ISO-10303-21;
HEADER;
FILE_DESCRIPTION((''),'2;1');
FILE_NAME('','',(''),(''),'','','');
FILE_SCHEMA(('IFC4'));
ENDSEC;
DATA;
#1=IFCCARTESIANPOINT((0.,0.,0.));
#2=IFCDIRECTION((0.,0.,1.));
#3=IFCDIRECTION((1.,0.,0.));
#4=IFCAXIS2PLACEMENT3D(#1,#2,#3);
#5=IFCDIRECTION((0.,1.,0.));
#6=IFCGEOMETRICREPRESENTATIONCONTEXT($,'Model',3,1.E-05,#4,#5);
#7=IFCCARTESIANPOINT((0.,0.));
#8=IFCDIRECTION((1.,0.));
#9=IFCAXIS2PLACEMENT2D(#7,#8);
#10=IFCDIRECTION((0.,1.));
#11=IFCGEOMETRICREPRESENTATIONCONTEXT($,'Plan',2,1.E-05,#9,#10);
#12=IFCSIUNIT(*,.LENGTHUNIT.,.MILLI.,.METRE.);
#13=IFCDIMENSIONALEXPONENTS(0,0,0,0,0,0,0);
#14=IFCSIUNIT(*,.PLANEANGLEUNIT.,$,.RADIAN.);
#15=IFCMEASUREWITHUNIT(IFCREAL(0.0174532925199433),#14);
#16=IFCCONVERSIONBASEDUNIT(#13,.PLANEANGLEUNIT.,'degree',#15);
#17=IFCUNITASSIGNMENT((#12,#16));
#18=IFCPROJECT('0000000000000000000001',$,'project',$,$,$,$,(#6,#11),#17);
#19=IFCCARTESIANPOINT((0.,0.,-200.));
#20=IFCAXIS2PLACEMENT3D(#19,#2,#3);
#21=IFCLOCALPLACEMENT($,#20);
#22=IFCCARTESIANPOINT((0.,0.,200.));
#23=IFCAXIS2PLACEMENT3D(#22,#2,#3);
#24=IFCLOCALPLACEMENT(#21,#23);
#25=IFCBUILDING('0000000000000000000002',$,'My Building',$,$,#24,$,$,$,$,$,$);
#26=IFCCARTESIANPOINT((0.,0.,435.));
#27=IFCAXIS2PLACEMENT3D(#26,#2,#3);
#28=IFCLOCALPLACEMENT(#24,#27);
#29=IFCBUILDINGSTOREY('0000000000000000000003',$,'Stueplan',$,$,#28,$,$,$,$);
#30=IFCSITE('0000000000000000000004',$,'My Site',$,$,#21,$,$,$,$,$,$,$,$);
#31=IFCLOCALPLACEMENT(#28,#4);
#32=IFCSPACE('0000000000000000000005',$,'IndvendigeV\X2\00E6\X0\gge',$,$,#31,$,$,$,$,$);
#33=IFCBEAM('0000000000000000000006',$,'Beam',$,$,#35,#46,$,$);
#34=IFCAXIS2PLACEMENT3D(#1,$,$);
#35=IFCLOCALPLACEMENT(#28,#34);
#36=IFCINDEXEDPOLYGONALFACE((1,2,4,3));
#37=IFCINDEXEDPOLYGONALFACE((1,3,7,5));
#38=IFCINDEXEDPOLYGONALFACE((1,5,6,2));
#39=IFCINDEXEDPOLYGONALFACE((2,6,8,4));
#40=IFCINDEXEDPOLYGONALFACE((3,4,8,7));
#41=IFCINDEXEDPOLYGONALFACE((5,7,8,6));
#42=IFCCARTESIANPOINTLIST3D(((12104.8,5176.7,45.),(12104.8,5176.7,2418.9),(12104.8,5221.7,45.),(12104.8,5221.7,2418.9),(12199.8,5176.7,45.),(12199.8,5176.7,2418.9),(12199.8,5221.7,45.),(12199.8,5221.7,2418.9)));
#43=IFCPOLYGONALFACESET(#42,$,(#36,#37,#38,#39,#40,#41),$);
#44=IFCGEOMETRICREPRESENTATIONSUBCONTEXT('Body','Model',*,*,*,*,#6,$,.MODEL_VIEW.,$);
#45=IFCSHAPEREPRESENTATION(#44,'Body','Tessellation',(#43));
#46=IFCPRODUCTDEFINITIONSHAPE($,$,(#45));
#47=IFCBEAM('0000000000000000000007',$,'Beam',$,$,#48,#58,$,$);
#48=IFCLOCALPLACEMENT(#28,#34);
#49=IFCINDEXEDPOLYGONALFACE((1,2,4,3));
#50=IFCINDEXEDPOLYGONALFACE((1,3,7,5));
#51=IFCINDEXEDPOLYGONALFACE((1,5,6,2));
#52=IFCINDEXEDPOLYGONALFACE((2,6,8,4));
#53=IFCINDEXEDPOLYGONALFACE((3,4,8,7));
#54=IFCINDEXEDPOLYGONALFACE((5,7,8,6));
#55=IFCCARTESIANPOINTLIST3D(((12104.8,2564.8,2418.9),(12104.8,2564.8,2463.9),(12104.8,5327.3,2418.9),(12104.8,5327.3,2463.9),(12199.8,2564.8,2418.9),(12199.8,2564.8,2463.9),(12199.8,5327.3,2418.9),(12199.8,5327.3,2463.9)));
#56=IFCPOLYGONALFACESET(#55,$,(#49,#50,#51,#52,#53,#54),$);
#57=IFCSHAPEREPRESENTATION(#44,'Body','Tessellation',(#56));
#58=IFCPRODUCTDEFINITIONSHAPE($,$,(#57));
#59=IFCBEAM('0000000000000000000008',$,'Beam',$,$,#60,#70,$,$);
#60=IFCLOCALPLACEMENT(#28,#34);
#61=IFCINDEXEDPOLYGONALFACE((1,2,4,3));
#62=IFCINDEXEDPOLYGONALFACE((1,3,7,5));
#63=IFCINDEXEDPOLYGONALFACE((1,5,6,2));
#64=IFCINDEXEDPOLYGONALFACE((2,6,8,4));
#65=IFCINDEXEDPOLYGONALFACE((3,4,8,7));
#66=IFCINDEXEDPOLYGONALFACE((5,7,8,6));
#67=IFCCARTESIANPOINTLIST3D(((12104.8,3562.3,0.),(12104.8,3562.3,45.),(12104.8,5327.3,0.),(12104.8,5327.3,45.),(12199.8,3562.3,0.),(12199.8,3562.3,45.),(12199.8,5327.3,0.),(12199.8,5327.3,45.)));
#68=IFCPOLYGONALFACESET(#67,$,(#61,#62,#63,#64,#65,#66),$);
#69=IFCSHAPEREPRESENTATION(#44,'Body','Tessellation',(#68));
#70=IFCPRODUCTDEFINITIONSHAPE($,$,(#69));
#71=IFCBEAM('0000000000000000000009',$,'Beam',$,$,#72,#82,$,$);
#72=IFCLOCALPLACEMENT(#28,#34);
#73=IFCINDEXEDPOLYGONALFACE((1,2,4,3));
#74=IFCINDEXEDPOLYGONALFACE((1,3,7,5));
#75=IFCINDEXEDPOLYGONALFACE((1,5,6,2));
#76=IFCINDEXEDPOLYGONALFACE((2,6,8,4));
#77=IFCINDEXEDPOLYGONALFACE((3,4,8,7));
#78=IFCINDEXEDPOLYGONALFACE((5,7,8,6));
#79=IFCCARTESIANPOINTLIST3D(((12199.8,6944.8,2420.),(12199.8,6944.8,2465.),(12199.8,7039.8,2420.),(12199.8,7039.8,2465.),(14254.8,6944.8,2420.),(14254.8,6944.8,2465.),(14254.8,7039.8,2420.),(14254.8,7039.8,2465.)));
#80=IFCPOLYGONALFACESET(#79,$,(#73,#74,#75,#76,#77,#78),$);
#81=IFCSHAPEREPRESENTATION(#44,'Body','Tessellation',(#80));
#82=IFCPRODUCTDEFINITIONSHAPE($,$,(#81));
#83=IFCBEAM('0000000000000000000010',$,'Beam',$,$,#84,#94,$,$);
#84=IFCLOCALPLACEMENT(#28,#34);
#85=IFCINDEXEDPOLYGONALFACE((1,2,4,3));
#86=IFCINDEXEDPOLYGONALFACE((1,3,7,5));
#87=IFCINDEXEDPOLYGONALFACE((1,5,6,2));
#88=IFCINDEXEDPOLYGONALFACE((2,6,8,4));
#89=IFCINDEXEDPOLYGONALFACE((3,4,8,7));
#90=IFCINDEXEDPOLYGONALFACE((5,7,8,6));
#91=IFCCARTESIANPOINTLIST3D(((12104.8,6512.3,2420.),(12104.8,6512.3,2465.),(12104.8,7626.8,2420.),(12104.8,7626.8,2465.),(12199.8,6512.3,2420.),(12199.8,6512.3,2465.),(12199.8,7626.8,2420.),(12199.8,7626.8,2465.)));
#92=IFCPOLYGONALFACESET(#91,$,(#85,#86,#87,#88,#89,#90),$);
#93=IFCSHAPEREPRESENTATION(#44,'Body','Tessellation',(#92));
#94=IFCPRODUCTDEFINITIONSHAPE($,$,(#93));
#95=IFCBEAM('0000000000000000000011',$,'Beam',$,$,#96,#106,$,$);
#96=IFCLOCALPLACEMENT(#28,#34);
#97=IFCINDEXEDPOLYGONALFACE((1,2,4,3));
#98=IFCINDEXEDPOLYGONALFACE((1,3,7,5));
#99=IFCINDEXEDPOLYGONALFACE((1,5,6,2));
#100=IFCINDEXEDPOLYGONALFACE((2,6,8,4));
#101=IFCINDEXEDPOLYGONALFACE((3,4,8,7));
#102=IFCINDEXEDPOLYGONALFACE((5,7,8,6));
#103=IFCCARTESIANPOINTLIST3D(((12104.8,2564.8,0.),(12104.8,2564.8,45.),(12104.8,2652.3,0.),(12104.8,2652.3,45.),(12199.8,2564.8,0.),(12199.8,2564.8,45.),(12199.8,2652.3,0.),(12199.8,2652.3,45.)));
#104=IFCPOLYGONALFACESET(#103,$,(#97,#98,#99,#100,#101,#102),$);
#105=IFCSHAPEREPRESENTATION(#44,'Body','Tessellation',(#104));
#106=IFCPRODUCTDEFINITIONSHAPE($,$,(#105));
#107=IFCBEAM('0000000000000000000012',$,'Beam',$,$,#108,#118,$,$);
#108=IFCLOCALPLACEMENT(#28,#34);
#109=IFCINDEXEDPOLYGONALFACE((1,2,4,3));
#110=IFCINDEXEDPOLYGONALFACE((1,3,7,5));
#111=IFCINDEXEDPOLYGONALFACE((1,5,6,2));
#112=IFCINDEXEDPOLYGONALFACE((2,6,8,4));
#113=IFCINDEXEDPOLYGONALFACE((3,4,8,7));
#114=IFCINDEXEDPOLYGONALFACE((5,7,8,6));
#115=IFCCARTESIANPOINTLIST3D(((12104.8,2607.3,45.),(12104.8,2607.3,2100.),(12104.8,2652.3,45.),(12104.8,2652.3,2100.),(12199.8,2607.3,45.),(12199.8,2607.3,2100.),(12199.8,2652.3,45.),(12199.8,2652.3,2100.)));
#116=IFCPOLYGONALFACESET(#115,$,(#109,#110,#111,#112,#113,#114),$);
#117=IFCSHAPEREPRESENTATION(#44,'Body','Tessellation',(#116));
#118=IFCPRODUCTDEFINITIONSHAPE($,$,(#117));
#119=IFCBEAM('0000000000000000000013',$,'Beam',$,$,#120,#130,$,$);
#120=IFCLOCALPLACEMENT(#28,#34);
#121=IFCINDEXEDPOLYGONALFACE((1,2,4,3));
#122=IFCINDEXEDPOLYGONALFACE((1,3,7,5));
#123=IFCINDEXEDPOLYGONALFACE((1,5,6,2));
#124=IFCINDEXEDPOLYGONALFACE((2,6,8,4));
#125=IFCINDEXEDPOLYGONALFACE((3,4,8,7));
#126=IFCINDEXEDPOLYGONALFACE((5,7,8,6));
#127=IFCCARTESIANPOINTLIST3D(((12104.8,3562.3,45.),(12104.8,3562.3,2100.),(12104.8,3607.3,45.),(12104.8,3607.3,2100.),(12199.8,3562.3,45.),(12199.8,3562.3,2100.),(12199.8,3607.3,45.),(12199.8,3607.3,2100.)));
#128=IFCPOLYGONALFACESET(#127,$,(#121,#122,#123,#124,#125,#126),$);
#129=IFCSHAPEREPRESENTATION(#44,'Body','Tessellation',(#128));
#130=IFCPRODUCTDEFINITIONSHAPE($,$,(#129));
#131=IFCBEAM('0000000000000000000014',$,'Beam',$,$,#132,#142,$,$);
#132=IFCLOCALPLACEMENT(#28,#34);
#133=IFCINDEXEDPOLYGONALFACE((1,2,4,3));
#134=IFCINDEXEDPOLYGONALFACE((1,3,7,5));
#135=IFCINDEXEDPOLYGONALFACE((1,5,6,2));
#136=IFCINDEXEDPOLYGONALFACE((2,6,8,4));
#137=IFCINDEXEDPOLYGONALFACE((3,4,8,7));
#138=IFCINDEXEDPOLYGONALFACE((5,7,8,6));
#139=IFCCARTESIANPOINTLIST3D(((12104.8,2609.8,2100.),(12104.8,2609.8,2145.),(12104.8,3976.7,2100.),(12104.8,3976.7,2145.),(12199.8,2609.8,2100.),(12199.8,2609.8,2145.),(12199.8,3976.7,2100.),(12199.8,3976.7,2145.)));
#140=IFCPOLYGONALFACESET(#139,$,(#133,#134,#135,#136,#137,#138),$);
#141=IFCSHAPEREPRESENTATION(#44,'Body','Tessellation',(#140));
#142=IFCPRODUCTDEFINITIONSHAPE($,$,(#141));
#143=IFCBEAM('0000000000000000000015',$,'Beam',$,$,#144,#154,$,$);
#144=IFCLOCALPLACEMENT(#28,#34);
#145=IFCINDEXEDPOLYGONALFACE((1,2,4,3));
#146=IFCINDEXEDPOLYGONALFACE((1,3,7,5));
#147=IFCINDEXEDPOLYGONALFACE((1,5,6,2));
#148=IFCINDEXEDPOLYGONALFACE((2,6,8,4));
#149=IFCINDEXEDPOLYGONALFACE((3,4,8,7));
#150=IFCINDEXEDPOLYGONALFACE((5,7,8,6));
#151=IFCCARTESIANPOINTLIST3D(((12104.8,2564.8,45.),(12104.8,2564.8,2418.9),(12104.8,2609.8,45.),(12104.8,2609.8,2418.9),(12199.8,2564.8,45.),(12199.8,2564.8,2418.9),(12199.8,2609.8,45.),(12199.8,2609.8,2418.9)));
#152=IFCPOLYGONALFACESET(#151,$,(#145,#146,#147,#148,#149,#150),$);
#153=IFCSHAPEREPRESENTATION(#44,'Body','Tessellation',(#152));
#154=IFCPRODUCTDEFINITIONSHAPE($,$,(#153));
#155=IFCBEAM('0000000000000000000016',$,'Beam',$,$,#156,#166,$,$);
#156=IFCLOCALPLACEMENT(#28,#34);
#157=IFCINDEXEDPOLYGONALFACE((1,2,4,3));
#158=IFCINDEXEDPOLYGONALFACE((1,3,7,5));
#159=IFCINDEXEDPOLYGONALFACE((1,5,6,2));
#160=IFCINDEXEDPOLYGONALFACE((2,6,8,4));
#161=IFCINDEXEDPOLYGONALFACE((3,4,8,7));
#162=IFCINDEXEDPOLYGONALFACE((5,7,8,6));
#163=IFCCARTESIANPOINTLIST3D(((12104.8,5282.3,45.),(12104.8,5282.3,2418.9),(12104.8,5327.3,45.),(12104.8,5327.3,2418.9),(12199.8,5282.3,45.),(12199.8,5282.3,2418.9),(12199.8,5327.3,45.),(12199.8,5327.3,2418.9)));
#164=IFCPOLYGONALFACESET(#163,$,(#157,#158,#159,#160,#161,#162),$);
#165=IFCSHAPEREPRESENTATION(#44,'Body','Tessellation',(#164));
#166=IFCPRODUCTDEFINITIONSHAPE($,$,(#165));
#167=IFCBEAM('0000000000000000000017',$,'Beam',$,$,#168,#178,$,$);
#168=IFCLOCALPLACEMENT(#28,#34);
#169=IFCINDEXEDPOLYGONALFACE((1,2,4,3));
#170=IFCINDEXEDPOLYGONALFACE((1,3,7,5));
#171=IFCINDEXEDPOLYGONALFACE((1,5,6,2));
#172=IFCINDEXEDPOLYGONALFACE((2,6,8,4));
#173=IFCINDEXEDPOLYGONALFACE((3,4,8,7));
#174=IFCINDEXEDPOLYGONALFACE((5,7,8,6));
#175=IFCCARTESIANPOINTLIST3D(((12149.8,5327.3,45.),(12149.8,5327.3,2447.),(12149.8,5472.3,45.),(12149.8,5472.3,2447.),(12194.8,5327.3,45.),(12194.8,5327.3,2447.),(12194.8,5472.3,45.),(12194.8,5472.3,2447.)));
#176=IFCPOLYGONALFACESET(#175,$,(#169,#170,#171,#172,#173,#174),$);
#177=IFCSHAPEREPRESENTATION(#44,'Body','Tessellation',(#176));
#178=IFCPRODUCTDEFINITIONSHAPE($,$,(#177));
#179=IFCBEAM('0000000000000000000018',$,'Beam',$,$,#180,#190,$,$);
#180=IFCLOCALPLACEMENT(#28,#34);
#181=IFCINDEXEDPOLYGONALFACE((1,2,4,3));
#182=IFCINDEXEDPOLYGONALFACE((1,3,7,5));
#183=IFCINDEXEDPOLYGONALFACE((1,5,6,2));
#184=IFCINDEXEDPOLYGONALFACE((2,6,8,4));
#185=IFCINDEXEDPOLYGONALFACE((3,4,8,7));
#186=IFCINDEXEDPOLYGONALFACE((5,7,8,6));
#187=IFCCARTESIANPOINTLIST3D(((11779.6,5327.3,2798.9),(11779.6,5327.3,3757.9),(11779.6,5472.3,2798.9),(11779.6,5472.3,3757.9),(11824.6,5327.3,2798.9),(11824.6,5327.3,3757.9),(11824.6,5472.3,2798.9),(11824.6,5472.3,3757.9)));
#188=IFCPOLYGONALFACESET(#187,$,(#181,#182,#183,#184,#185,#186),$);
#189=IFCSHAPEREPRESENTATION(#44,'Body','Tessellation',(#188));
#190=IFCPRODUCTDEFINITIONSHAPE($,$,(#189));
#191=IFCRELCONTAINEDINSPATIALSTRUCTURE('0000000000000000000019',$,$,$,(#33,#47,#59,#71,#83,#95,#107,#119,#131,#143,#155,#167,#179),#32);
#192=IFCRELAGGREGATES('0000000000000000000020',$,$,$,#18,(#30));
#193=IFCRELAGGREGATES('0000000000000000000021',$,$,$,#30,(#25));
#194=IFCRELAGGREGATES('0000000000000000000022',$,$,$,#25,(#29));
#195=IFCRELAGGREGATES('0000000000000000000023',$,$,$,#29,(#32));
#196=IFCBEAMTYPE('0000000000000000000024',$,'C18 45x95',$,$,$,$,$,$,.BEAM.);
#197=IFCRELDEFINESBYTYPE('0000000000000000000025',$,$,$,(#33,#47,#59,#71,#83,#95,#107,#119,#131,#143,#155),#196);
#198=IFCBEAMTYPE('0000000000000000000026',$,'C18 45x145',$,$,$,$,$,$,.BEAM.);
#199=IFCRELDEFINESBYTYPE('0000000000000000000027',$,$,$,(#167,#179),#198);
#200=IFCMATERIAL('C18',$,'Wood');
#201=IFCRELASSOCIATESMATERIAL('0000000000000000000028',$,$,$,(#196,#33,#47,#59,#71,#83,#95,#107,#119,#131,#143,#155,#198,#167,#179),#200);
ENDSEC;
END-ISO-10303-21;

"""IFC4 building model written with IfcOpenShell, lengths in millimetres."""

from ifc_helpers import new_model, entity, si_unit, converted_unit, direction, frame, origin_with_axes, origin_2d_with_axis, place, context, subcontext, project, spatial, rectangle, extrude, material, material_profile, profile_set, profile_usage, type_object, element, save


model = new_model("IFC4")

# Units and contexts
model_context = context("Model", 3, precision=1e-05, world=origin_with_axes(), true_north=direction((0.0, 1.0, 0.0)))
plan_context = context("Plan", 2, precision=1e-05, world=origin_2d_with_axis(), true_north=direction((0.0, 1.0)))
body_context_1 = subcontext(model_context, "Body", "Model", "MODEL_VIEW")
ifc_project = project(units=[si_unit("LENGTHUNIT", "METRE", prefix="MILLI"), converted_unit("PLANEANGLEUNIT", "degree", entity("IfcReal", 0.0174532925199433), si_unit("PLANEANGLEUNIT", "RADIAN"), dimensions=[0, 0, 0, 0, 0, 0, 0])], contexts=[model_context, plan_context])

# Site, building, storey, space
site_placement = place(None, frame((0.0, 0.0, -200.0), z_axis=(0.0, 0.0, 1.0), x_axis=(1.0, 0.0, 0.0)))
site = spatial("IfcSite", under=ifc_project, at=site_placement, Name="My Site")
building_placement = place(site_placement, frame((0.0, 0.0, 200.0), z_axis=(0.0, 0.0, 1.0), x_axis=(1.0, 0.0, 0.0)))
building = spatial("IfcBuilding", under=site, at=building_placement, Name="My Building")
storey_placement = place(building_placement, frame((0.0, 0.0, 435.0), z_axis=(0.0, 0.0, 1.0), x_axis=(1.0, 0.0, 0.0)))
storey = spatial("IfcBuildingStorey", under=building, at=storey_placement, Name="Stueplan")
space_1_placement = place(storey_placement, frame((0.0, 0.0, 0.0), z_axis=(0.0, 0.0, 1.0), x_axis=(1.0, 0.0, 0.0)))
space_1 = spatial("IfcSpace", under=storey, at=space_1_placement, Name="IndvendigeVægge")

# Beams
ifc_material = material(Name="C18", Category="Wood")
ifc_material_profile_1 = material_profile(ifc_material, rectangle(XDim=45.0, YDim=95.0))
ifc_profile_set_1 = profile_set([ifc_material_profile_1], Name="woodStructural")
beam_type_1 = type_object("IfcBeamType", Name="C18 45x95", PredefinedType="BEAM", material=ifc_profile_set_1)
ifc_profile_usage_1 = profile_usage(ifc_profile_set_1)
beam_1_placement = place(space_1_placement, frame((12152.3, 5199.2, 45.0), z_axis=(0.0, 0.0, 1.0), x_axis=(0.0, -1.0, 0.0)))
element("IfcBeam", 1, at=beam_1_placement, inside=space_1, type_object=beam_type_1, material=ifc_profile_usage_1, Name="Beam", context=body_context_1, shape_type="SweptSolid", body=[
    extrude(rectangle(XDim=45.0, YDim=95.0), origin_with_axes(), (0.0, 0.0, 1.0), 2373.9),
])
ifc_profile_usage_2 = profile_usage(ifc_profile_set_1, cardinal=5)
beam_2_placement = place(space_1_placement, frame((12152.3, 2564.8, 2441.4), z_axis=(0.0, 1.0, 0.0), x_axis=(0.0, 0.0, 1.0)))
element("IfcBeam", 2, at=beam_2_placement, inside=space_1, type_object=beam_type_1, material=ifc_profile_usage_2, Name="Beam", context=body_context_1, shape_type="SweptSolid", body=[
    extrude(rectangle(XDim=45.0, YDim=95.0), origin_with_axes(), (0.0, 0.0, 1.0), 2762.5),
])
ifc_profile_usage_3 = profile_usage(ifc_profile_set_1, cardinal=5)
beam_3_placement = place(space_1_placement, frame((12152.3, 3562.3, 22.5), z_axis=(0.0, 1.0, 0.0), x_axis=(0.0, 0.0, 1.0)))
element("IfcBeam", 3, at=beam_3_placement, inside=space_1, type_object=beam_type_1, material=ifc_profile_usage_3, Name="Beam", context=body_context_1, shape_type="SweptSolid", body=[
    extrude(rectangle(XDim=45.0, YDim=95.0), origin_with_axes(), (0.0, 0.0, 1.0), 1765.0),
])
ifc_profile_usage_4 = profile_usage(ifc_profile_set_1, cardinal=5)
beam_4_placement = place(space_1_placement, frame((12199.8, 6992.3, 2442.5), z_axis=(1.0, 0.0, 0.0), x_axis=(0.0, 0.0, 1.0)))
element("IfcBeam", 4, at=beam_4_placement, inside=space_1, type_object=beam_type_1, material=ifc_profile_usage_4, Name="Beam", context=body_context_1, shape_type="SweptSolid", body=[
    extrude(rectangle(XDim=45.0, YDim=95.0), origin_with_axes(), (0.0, 0.0, 1.0), 2055.0),
])
ifc_profile_usage_5 = profile_usage(ifc_profile_set_1, cardinal=5)
beam_5_placement = place(space_1_placement, frame((12152.3, 6512.3, 2442.5), z_axis=(0.0, 1.0, 0.0), x_axis=(0.0, 0.0, 1.0)))
element("IfcBeam", 5, at=beam_5_placement, inside=space_1, type_object=beam_type_1, material=ifc_profile_usage_5, Name="Beam", context=body_context_1, shape_type="SweptSolid", body=[
    extrude(rectangle(XDim=45.0, YDim=95.0), origin_with_axes(), (0.0, 0.0, 1.0), 1114.5),
])
ifc_profile_usage_6 = profile_usage(ifc_profile_set_1, cardinal=5)
beam_6_placement = place(space_1_placement, frame((12152.3, 2652.3, 22.5), z_axis=(0.0, -1.0, 0.0), x_axis=(0.0, 0.0, 1.0)))
element("IfcBeam", 6, at=beam_6_placement, inside=space_1, type_object=beam_type_1, material=ifc_profile_usage_6, Name="Beam", context=body_context_1, shape_type="SweptSolid", body=[
    extrude(rectangle(XDim=45.0, YDim=95.0), origin_with_axes(), (0.0, 0.0, 1.0), 87.5),
])
ifc_profile_usage_7 = profile_usage(ifc_profile_set_1)
beam_7_placement = place(space_1_placement, frame((12152.3, 2629.8, 45.0), z_axis=(0.0, 0.0, 1.0), x_axis=(0.0, -1.0, 0.0)))
element("IfcBeam", 7, at=beam_7_placement, inside=space_1, type_object=beam_type_1, material=ifc_profile_usage_7, Name="Beam", context=body_context_1, shape_type="SweptSolid", body=[
    extrude(rectangle(XDim=45.0, YDim=95.0), origin_with_axes(), (0.0, 0.0, 1.0), 2055.0),
])
ifc_profile_usage_8 = profile_usage(ifc_profile_set_1)
beam_8_placement = place(space_1_placement, frame((12152.3, 3584.8, 45.0), z_axis=(0.0, 0.0, 1.0), x_axis=(0.0, -1.0, 0.0)))
element("IfcBeam", 8, at=beam_8_placement, inside=space_1, type_object=beam_type_1, material=ifc_profile_usage_8, Name="Beam", context=body_context_1, shape_type="SweptSolid", body=[
    extrude(rectangle(XDim=45.0, YDim=95.0), origin_with_axes(), (0.0, 0.0, 1.0), 2055.0),
])
ifc_profile_usage_9 = profile_usage(ifc_profile_set_1, cardinal=5)
beam_9_placement = place(space_1_placement, frame((12152.3, 3976.7, 2122.5), z_axis=(0.0, -1.0, 0.0), x_axis=(0.0, 0.0, 1.0)))
element("IfcBeam", 9, at=beam_9_placement, inside=space_1, type_object=beam_type_1, material=ifc_profile_usage_9, Name="Beam", context=body_context_1, shape_type="SweptSolid", body=[
    extrude(rectangle(XDim=45.0, YDim=95.0), origin_with_axes(), (0.0, 0.0, 1.0), 1366.9),
])
ifc_profile_usage_10 = profile_usage(ifc_profile_set_1)
beam_10_placement = place(space_1_placement, frame((12152.3, 2587.3, 45.0), z_axis=(0.0, 0.0, 1.0), x_axis=(0.0, -1.0, 0.0)))
element("IfcBeam", 10, at=beam_10_placement, inside=space_1, type_object=beam_type_1, material=ifc_profile_usage_10, Name="Beam", context=body_context_1, shape_type="SweptSolid", body=[
    extrude(rectangle(XDim=45.0, YDim=95.0), origin_with_axes(), (0.0, 0.0, 1.0), 2373.9),
])
ifc_profile_usage_11 = profile_usage(ifc_profile_set_1)
beam_11_placement = place(space_1_placement, frame((12152.3, 5304.8, 45.0), z_axis=(0.0, 0.0, 1.0), x_axis=(0.0, -1.0, 0.0)))
element("IfcBeam", 11, at=beam_11_placement, inside=space_1, type_object=beam_type_1, material=ifc_profile_usage_11, Name="Beam", context=body_context_1, shape_type="SweptSolid", body=[
    extrude(rectangle(XDim=45.0, YDim=95.0), origin_with_axes(), (0.0, 0.0, 1.0), 2373.9),
])
ifc_material_profile_2 = material_profile(ifc_material, rectangle(XDim=45.0, YDim=145.0))
ifc_profile_set_2 = profile_set([ifc_material_profile_2], Name="woodStructural")
ifc_profile_usage_12 = profile_usage(ifc_profile_set_2)
beam_type_2 = type_object("IfcBeamType", Name="C18 45x145", PredefinedType="BEAM", material=ifc_profile_set_2)
beam_12_placement = place(space_1_placement, frame((12172.3, 5399.8, 45.0), z_axis=(0.0, 0.0, 1.0), x_axis=(-1.0, 0.0, 0.0)))
element("IfcBeam", 12, at=beam_12_placement, inside=space_1, type_object=beam_type_2, material=ifc_profile_usage_12, Name="Beam", context=body_context_1, shape_type="SweptSolid", body=[
    extrude(rectangle(XDim=45.0, YDim=145.0), origin_with_axes(), (0.0, 0.0, 1.0), 2402.0),
])
ifc_profile_usage_13 = profile_usage(ifc_profile_set_2)
beam_13_placement = place(space_1_placement, frame((11802.1, 5399.8, 2798.9), z_axis=(0.0, 0.0, 1.0), x_axis=(-1.0, 0.0, 0.0)))
element("IfcBeam", 13, at=beam_13_placement, inside=space_1, type_object=beam_type_2, material=ifc_profile_usage_13, Name="Beam", context=body_context_1, shape_type="SweptSolid", body=[
    extrude(rectangle(XDim=45.0, YDim=145.0), origin_with_axes(), (0.0, 0.0, 1.0), 958.9),
])

save(model, "model.ifc")
